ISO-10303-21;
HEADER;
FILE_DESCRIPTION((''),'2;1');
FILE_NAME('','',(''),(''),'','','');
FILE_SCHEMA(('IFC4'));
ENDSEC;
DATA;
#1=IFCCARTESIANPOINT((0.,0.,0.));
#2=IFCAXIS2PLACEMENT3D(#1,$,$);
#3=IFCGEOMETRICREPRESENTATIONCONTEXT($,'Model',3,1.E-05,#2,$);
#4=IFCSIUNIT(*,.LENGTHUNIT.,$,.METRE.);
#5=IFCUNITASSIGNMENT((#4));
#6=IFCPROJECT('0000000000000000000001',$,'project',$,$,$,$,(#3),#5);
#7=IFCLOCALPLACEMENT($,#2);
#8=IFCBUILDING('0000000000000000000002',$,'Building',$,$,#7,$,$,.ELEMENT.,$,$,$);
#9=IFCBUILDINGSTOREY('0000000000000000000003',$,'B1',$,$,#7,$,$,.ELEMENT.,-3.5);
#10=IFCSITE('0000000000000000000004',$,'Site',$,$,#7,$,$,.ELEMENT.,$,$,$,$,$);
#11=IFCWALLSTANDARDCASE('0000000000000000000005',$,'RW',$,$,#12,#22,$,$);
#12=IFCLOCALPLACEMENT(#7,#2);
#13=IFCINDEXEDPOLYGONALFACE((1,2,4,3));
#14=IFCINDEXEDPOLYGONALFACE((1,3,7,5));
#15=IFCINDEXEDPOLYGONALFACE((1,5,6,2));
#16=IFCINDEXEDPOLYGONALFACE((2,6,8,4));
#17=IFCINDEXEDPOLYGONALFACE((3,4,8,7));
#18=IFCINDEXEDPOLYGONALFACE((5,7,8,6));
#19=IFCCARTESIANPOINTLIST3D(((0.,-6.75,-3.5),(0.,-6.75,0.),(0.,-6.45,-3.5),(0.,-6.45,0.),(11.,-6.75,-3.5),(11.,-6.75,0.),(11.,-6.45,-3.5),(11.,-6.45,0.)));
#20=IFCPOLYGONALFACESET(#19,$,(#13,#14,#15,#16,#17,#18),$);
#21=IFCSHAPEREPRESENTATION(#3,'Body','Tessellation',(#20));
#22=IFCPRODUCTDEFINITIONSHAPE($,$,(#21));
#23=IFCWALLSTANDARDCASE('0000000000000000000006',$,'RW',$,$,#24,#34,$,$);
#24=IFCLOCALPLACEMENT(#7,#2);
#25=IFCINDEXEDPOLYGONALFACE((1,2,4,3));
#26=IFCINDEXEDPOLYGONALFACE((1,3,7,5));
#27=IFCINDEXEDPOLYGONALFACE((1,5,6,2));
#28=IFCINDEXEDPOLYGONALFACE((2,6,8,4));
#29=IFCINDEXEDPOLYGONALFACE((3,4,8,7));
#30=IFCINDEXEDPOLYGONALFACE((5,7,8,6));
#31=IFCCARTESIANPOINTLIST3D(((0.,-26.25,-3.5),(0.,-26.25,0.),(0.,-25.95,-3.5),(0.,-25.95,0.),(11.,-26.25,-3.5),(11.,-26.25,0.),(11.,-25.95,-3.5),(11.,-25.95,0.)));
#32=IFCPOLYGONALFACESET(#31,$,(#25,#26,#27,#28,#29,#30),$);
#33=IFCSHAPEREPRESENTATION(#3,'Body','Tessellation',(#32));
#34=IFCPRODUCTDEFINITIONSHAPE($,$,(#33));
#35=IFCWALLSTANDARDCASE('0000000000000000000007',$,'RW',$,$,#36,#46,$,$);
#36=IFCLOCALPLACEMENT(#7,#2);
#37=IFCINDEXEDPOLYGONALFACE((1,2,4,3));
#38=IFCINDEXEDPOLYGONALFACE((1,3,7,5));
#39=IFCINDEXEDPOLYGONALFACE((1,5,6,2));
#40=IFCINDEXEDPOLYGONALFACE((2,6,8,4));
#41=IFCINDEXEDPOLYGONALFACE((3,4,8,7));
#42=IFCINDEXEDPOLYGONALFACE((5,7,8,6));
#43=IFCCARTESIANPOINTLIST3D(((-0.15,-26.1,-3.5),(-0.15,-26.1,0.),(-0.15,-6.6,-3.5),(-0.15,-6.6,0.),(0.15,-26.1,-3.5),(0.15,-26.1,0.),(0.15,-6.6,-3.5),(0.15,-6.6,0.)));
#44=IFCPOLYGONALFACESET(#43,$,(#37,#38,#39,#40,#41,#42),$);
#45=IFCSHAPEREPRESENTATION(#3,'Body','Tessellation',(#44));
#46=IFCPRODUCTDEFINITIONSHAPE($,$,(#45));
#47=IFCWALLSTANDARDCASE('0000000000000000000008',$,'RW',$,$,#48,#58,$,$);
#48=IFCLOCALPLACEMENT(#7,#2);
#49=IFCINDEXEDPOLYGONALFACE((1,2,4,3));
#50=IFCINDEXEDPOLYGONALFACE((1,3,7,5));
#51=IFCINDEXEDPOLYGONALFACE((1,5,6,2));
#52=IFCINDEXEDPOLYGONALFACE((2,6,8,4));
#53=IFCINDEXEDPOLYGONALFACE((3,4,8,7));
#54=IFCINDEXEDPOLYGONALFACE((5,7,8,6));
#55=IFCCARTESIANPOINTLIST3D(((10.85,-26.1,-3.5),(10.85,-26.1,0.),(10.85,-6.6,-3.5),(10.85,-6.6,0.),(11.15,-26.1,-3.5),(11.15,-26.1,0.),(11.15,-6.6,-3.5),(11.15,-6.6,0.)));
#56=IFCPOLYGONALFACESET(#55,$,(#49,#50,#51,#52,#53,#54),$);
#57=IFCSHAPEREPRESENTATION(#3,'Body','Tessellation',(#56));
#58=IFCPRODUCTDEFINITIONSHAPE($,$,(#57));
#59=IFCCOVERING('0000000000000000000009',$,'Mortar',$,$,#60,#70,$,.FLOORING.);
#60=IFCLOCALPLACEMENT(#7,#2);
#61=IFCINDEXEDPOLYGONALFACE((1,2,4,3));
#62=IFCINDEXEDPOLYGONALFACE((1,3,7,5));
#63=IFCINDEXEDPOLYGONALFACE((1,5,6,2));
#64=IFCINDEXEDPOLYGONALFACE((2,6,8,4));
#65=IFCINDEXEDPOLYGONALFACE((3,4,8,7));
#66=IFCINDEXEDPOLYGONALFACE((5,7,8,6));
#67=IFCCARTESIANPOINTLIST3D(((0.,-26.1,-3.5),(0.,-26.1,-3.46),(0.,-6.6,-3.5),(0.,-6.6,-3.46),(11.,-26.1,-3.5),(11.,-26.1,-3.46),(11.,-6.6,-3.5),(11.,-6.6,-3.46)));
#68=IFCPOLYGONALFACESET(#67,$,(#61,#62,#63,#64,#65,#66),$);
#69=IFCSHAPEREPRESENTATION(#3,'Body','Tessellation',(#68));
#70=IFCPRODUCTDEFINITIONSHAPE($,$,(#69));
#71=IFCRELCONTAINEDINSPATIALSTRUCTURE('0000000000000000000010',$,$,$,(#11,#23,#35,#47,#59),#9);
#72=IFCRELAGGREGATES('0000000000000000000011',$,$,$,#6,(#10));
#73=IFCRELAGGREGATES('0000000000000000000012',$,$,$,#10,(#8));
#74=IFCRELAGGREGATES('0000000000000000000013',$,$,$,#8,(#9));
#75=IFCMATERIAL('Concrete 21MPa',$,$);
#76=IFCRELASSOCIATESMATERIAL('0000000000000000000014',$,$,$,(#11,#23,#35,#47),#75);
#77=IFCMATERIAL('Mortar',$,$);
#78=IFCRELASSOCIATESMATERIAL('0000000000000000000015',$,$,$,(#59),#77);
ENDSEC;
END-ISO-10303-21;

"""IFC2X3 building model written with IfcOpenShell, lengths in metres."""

from ifc_helpers import new_model, si_unit, frame, origin, origin_2d, place, context, project, spatial, rectangle, extrude, material, element, save


model = new_model("IFC2X3")

# Units and contexts
model_context = context("Model", 3, precision=1e-05, world=origin())
ifc_project = project(units=[si_unit("LENGTHUNIT", "METRE")], contexts=[model_context])

# Site, building, storey
placement = place(None, origin())
site = spatial("IfcSite", under=ifc_project, at=placement, Name="Site", CompositionType="ELEMENT")
building = spatial("IfcBuilding", under=site, at=placement, Name="Building", CompositionType="ELEMENT")
storey = spatial("IfcBuildingStorey", under=building, at=placement, Name="B1", CompositionType="ELEMENT", Elevation=-3.5)

# Shared definitions
ifc_material_1 = material(Name="Concrete 21MPa")

# Walls
for number, where, name in (
    (1, (5.5, -6.6, -3.5), "RW"),
    (2, (5.5, -26.1, -3.5), "RW"),
):
    element("IfcWallStandardCase", number, at=place(None, frame(where)), inside=storey, material=ifc_material_1, Name=name, context=model_context, shape_type="SweptSolid", body=[
        extrude(rectangle(XDim=11.0, YDim=0.3, at=origin_2d()), origin(), (0.0, 0.0, 1.0), 3.5),
    ])
for number, where, name in (
    (3, (0.0, -16.35, -3.5), "RW"),
    (4, (11.0, -16.35, -3.5), "RW"),
):
    element("IfcWallStandardCase", number, at=place(None, frame(where)), inside=storey, material=ifc_material_1, Name=name, context=model_context, shape_type="SweptSolid", body=[
        extrude(rectangle(XDim=0.3, YDim=19.5, at=origin_2d()), origin(), (0.0, 0.0, 1.0), 3.5),
    ])

# Covering
ifc_material_2 = material(Name="Mortar")
covering_placement = place(None, frame((5.5, -16.35, -3.5)))
element("IfcCovering", 5, at=covering_placement, inside=storey, material=ifc_material_2, Name="Mortar", PredefinedType="FLOORING", context=model_context, shape_type="SweptSolid", body=[
    extrude(rectangle(XDim=11.0, YDim=19.5, at=origin_2d()), origin(), (0.0, 0.0, 1.0), 0.04),
])

save(model, "model.ifc")
